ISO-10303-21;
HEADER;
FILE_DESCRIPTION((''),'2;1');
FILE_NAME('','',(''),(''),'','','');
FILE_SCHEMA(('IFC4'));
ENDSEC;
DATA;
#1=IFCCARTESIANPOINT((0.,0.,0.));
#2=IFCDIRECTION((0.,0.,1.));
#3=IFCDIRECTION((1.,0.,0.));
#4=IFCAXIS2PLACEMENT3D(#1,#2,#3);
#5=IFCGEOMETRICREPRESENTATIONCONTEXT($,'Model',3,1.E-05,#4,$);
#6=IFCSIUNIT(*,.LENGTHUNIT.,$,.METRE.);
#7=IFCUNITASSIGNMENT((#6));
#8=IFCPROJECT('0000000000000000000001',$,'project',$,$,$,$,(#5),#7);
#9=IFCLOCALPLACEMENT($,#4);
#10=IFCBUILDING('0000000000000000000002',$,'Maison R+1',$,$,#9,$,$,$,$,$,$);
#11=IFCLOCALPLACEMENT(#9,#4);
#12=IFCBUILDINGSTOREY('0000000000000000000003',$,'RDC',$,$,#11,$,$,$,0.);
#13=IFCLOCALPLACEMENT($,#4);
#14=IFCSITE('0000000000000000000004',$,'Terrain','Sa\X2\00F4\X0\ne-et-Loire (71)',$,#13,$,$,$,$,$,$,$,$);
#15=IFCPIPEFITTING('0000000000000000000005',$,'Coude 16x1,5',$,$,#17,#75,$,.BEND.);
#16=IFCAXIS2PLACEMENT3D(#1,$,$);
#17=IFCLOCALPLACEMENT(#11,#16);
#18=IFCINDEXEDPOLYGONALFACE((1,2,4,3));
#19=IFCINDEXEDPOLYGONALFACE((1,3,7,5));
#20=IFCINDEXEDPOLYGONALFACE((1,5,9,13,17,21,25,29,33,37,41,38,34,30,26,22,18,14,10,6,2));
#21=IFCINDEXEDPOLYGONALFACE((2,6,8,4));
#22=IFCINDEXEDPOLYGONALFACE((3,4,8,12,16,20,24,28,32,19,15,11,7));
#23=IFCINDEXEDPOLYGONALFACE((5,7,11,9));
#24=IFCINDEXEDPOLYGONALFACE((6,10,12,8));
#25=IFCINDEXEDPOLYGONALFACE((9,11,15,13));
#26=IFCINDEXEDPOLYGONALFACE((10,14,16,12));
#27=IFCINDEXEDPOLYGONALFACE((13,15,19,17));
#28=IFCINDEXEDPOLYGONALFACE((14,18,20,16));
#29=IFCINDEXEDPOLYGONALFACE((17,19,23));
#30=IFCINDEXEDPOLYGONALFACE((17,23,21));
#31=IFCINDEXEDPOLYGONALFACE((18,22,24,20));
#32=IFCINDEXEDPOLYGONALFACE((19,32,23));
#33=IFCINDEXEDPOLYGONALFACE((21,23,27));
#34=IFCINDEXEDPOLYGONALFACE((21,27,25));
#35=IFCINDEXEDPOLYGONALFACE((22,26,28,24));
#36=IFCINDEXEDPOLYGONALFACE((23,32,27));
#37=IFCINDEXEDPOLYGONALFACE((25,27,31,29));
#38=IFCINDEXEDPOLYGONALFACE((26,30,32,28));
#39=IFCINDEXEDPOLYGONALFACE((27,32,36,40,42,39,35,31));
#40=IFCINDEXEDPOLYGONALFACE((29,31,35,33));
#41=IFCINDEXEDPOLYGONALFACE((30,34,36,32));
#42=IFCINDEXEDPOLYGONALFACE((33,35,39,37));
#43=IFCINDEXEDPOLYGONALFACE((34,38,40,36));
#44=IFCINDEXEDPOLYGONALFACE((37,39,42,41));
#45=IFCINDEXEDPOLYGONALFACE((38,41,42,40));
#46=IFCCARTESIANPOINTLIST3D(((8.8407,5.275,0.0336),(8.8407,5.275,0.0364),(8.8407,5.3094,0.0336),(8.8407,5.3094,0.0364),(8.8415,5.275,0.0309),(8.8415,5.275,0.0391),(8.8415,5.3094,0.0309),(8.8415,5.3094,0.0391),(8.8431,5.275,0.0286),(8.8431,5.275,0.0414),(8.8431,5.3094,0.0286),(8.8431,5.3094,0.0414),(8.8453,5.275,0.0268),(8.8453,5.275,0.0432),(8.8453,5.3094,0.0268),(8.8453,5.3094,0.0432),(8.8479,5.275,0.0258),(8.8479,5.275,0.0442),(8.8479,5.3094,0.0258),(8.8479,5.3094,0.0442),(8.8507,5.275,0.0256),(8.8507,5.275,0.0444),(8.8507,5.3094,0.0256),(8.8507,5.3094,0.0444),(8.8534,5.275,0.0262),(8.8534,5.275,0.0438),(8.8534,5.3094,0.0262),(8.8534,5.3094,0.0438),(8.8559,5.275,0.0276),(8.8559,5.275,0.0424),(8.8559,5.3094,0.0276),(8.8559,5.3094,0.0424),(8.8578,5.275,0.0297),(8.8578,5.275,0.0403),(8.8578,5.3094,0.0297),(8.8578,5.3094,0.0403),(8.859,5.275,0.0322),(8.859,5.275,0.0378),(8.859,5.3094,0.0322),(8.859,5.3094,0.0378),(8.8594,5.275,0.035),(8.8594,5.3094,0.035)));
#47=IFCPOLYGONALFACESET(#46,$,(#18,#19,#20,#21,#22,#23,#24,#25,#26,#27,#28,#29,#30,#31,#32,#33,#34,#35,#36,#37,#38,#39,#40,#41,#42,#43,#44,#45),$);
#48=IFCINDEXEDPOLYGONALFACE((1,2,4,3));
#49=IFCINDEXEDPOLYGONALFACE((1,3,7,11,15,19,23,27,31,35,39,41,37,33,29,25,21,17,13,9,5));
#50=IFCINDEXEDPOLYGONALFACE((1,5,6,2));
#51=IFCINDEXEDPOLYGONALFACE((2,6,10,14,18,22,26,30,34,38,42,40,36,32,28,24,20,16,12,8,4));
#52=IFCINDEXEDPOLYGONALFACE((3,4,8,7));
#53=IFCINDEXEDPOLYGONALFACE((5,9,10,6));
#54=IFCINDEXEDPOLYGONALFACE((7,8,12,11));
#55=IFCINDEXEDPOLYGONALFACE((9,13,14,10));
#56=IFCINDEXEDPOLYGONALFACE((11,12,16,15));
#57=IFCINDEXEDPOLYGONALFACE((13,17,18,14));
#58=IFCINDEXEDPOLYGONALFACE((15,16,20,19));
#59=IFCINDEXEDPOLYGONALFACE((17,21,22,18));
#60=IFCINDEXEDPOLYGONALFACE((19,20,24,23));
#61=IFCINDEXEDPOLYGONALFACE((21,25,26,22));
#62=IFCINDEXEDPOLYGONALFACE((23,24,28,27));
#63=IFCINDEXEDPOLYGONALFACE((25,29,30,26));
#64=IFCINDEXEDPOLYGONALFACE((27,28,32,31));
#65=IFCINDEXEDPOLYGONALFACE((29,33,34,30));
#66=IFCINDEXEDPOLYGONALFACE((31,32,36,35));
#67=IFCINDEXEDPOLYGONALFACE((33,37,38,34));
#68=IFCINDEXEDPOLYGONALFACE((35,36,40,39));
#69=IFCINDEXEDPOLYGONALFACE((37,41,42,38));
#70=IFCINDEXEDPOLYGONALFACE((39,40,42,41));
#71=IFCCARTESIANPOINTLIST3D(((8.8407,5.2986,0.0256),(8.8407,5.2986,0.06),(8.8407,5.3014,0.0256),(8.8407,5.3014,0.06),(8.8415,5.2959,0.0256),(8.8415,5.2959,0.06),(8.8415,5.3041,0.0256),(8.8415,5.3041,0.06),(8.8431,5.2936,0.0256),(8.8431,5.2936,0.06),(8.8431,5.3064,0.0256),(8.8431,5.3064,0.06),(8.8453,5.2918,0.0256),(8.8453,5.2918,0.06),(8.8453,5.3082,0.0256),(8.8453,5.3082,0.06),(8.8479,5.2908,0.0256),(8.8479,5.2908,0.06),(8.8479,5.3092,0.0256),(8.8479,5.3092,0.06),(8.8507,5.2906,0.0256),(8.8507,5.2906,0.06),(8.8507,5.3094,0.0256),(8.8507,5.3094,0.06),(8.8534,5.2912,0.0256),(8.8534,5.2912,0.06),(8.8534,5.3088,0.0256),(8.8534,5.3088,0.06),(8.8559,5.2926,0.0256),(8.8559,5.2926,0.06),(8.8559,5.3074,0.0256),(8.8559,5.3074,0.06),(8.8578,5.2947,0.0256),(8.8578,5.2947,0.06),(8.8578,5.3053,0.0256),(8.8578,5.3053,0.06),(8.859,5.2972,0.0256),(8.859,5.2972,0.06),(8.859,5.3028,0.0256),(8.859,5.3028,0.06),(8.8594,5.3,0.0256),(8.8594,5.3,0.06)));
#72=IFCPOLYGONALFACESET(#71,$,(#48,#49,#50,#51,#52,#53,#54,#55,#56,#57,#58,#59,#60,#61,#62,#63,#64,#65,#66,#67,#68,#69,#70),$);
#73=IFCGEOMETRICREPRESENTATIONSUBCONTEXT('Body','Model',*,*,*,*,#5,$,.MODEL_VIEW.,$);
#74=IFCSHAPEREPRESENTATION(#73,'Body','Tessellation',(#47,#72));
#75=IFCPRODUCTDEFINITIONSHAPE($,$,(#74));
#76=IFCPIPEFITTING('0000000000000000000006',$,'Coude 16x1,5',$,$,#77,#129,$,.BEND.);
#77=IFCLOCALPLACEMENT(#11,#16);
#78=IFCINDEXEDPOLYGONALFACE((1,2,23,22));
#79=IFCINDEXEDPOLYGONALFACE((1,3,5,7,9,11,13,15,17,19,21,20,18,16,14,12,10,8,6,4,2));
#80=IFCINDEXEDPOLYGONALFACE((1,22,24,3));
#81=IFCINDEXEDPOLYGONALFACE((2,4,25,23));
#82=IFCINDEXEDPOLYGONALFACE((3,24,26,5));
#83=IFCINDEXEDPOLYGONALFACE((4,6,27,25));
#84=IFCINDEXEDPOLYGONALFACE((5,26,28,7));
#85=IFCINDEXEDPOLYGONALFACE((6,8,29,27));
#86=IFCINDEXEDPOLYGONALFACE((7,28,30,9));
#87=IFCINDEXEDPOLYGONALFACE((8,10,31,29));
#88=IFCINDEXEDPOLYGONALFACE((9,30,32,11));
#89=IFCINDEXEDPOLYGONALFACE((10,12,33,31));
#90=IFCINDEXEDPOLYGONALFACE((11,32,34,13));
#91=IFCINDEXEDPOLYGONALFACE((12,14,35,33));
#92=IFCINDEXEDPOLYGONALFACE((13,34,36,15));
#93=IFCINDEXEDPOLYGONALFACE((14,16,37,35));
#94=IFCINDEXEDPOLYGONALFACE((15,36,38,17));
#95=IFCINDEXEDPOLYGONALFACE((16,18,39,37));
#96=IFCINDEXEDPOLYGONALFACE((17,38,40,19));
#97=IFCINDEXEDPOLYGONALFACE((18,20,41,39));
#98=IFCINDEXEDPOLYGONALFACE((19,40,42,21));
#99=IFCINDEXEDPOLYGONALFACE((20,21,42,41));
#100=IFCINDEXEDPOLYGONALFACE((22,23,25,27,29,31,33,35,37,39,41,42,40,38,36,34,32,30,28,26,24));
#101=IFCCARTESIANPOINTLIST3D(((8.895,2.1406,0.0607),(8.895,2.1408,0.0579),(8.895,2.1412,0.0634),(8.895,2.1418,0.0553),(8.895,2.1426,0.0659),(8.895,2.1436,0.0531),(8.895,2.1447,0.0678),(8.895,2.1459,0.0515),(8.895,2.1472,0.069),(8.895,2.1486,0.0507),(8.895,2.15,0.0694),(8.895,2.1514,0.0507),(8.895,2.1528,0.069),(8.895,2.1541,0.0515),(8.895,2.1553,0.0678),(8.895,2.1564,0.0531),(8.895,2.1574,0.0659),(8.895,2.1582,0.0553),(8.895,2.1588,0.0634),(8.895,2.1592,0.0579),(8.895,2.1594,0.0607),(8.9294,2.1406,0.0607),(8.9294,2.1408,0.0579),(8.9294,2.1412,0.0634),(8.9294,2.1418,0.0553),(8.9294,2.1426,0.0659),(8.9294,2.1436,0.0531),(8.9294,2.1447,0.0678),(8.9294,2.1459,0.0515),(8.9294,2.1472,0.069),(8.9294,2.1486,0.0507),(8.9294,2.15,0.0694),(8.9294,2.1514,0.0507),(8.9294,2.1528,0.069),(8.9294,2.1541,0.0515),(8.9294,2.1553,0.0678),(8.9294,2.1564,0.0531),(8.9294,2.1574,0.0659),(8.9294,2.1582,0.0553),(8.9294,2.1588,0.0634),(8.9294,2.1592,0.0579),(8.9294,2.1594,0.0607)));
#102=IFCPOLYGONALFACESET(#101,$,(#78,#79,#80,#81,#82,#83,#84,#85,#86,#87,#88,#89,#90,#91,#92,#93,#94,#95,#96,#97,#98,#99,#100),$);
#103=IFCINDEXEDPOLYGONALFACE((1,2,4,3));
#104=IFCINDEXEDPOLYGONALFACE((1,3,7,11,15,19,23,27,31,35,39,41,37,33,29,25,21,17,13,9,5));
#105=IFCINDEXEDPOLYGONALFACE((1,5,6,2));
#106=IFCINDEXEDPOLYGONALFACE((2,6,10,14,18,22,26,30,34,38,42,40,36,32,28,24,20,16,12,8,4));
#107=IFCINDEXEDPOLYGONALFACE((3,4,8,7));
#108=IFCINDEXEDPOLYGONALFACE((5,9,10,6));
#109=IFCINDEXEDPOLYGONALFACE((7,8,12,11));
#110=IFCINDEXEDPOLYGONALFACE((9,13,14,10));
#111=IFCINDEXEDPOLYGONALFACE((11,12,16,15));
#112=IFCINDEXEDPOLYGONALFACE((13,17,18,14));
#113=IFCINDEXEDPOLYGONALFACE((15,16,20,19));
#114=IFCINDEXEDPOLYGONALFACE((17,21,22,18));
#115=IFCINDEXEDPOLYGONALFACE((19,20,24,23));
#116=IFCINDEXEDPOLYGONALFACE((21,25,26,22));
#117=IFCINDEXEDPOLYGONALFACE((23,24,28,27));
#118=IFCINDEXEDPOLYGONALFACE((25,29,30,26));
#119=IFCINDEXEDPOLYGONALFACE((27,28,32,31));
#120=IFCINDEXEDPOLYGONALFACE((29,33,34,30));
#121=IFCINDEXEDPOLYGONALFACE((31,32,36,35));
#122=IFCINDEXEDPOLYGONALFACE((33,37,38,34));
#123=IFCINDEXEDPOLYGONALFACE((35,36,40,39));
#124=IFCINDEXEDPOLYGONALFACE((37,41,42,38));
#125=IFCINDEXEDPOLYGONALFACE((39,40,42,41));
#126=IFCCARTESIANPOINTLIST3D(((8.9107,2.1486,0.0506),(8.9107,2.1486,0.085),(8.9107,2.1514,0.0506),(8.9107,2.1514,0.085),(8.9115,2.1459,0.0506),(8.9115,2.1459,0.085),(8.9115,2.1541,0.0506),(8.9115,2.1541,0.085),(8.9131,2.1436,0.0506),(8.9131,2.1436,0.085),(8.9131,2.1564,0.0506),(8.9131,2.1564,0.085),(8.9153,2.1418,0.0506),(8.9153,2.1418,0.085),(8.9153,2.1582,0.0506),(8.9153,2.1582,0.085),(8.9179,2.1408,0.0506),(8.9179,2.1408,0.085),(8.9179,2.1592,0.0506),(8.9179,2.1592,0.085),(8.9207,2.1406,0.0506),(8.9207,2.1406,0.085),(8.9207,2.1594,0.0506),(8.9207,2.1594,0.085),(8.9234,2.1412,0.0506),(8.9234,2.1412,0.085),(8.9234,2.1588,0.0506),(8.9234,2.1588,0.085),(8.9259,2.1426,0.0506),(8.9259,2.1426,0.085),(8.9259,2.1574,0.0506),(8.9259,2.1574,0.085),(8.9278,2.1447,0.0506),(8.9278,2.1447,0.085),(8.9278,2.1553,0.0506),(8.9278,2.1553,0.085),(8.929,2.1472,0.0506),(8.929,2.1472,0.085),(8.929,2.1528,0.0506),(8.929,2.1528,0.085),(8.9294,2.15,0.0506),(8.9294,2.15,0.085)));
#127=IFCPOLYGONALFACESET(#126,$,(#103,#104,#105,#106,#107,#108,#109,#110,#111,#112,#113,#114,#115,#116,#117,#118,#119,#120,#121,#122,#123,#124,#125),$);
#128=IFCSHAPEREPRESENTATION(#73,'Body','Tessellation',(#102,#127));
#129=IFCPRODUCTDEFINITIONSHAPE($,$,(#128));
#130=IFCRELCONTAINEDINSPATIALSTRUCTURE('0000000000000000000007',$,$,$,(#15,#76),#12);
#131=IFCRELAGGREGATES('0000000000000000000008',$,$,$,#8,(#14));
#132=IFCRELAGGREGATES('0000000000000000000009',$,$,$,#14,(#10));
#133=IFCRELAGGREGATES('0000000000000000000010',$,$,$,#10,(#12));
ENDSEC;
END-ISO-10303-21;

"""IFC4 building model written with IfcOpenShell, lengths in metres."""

from ifc_helpers import new_model, si_unit, frame, origin_with_axes, place, context, subcontext, project, spatial, circle, extrude, element, save


model = new_model("IFC4")

# Units and contexts
model_context = context("Model", 3, precision=1e-05, world=origin_with_axes())
body_context = subcontext(model_context, "Body", "Model", "MODEL_VIEW")
ifc_project = project(units=[si_unit("LENGTHUNIT", "METRE")], contexts=[model_context])

# Site, building, storey
site_placement = place(None, origin_with_axes())
site = spatial("IfcSite", under=ifc_project, at=site_placement, Name="Terrain", Description="Saône-et-Loire (71)")
building_placement = place(None, origin_with_axes())
building = spatial("IfcBuilding", under=site, at=building_placement, Name="Maison R+1")
storey_placement = place(building_placement, origin_with_axes())
storey = spatial("IfcBuildingStorey", under=building, at=storey_placement, Name="RDC", Elevation=0.0)

# Pipe fittings
pipe_fitting_1_placement = place(storey_placement, frame((8.85, 5.3, 0.035), z_axis=(0.0, 0.0, 1.0), x_axis=(1.0, 0.0, 0.0)))
element("IfcPipeFitting", 1, at=pipe_fitting_1_placement, inside=storey, Name="Coude 16x1,5", PredefinedType="BEND", context=body_context, shape_type="SweptSolid", body=[
    extrude(circle(Radius=0.0094), frame((0.0, 0.0094, 0.0), z_axis=(0.0, -1.0, 0.0), x_axis=(1.0, 0.0, 0.0)), (0.0, 0.0, 1.0), 0.0344),
    extrude(circle(Radius=0.0094), frame((0.0, 0.0, -0.0094), z_axis=(0.0, 0.0, 1.0), x_axis=(1.0, 0.0, 0.0)), (0.0, 0.0, 1.0), 0.0344),
])
pipe_fitting_2_placement = place(storey_placement, frame((8.92, 2.15, 0.06), z_axis=(0.0, 0.0, 1.0), x_axis=(1.0, 0.0, 0.0)))
element("IfcPipeFitting", 2, at=pipe_fitting_2_placement, inside=storey, Name="Coude 16x1,5", PredefinedType="BEND", context=body_context, shape_type="SweptSolid", body=[
    extrude(circle(Radius=0.0094), frame((0.0094, 0.0, 0.0), z_axis=(-1.0, 0.0, 0.0), x_axis=(0.0, 0.0, 1.0)), (0.0, 0.0, 1.0), 0.0344),
    extrude(circle(Radius=0.0094), frame((0.0, 0.0, -0.0094), z_axis=(0.0, 0.0, 1.0), x_axis=(1.0, 0.0, 0.0)), (0.0, 0.0, 1.0), 0.0344),
])

save(model, "model.ifc")
